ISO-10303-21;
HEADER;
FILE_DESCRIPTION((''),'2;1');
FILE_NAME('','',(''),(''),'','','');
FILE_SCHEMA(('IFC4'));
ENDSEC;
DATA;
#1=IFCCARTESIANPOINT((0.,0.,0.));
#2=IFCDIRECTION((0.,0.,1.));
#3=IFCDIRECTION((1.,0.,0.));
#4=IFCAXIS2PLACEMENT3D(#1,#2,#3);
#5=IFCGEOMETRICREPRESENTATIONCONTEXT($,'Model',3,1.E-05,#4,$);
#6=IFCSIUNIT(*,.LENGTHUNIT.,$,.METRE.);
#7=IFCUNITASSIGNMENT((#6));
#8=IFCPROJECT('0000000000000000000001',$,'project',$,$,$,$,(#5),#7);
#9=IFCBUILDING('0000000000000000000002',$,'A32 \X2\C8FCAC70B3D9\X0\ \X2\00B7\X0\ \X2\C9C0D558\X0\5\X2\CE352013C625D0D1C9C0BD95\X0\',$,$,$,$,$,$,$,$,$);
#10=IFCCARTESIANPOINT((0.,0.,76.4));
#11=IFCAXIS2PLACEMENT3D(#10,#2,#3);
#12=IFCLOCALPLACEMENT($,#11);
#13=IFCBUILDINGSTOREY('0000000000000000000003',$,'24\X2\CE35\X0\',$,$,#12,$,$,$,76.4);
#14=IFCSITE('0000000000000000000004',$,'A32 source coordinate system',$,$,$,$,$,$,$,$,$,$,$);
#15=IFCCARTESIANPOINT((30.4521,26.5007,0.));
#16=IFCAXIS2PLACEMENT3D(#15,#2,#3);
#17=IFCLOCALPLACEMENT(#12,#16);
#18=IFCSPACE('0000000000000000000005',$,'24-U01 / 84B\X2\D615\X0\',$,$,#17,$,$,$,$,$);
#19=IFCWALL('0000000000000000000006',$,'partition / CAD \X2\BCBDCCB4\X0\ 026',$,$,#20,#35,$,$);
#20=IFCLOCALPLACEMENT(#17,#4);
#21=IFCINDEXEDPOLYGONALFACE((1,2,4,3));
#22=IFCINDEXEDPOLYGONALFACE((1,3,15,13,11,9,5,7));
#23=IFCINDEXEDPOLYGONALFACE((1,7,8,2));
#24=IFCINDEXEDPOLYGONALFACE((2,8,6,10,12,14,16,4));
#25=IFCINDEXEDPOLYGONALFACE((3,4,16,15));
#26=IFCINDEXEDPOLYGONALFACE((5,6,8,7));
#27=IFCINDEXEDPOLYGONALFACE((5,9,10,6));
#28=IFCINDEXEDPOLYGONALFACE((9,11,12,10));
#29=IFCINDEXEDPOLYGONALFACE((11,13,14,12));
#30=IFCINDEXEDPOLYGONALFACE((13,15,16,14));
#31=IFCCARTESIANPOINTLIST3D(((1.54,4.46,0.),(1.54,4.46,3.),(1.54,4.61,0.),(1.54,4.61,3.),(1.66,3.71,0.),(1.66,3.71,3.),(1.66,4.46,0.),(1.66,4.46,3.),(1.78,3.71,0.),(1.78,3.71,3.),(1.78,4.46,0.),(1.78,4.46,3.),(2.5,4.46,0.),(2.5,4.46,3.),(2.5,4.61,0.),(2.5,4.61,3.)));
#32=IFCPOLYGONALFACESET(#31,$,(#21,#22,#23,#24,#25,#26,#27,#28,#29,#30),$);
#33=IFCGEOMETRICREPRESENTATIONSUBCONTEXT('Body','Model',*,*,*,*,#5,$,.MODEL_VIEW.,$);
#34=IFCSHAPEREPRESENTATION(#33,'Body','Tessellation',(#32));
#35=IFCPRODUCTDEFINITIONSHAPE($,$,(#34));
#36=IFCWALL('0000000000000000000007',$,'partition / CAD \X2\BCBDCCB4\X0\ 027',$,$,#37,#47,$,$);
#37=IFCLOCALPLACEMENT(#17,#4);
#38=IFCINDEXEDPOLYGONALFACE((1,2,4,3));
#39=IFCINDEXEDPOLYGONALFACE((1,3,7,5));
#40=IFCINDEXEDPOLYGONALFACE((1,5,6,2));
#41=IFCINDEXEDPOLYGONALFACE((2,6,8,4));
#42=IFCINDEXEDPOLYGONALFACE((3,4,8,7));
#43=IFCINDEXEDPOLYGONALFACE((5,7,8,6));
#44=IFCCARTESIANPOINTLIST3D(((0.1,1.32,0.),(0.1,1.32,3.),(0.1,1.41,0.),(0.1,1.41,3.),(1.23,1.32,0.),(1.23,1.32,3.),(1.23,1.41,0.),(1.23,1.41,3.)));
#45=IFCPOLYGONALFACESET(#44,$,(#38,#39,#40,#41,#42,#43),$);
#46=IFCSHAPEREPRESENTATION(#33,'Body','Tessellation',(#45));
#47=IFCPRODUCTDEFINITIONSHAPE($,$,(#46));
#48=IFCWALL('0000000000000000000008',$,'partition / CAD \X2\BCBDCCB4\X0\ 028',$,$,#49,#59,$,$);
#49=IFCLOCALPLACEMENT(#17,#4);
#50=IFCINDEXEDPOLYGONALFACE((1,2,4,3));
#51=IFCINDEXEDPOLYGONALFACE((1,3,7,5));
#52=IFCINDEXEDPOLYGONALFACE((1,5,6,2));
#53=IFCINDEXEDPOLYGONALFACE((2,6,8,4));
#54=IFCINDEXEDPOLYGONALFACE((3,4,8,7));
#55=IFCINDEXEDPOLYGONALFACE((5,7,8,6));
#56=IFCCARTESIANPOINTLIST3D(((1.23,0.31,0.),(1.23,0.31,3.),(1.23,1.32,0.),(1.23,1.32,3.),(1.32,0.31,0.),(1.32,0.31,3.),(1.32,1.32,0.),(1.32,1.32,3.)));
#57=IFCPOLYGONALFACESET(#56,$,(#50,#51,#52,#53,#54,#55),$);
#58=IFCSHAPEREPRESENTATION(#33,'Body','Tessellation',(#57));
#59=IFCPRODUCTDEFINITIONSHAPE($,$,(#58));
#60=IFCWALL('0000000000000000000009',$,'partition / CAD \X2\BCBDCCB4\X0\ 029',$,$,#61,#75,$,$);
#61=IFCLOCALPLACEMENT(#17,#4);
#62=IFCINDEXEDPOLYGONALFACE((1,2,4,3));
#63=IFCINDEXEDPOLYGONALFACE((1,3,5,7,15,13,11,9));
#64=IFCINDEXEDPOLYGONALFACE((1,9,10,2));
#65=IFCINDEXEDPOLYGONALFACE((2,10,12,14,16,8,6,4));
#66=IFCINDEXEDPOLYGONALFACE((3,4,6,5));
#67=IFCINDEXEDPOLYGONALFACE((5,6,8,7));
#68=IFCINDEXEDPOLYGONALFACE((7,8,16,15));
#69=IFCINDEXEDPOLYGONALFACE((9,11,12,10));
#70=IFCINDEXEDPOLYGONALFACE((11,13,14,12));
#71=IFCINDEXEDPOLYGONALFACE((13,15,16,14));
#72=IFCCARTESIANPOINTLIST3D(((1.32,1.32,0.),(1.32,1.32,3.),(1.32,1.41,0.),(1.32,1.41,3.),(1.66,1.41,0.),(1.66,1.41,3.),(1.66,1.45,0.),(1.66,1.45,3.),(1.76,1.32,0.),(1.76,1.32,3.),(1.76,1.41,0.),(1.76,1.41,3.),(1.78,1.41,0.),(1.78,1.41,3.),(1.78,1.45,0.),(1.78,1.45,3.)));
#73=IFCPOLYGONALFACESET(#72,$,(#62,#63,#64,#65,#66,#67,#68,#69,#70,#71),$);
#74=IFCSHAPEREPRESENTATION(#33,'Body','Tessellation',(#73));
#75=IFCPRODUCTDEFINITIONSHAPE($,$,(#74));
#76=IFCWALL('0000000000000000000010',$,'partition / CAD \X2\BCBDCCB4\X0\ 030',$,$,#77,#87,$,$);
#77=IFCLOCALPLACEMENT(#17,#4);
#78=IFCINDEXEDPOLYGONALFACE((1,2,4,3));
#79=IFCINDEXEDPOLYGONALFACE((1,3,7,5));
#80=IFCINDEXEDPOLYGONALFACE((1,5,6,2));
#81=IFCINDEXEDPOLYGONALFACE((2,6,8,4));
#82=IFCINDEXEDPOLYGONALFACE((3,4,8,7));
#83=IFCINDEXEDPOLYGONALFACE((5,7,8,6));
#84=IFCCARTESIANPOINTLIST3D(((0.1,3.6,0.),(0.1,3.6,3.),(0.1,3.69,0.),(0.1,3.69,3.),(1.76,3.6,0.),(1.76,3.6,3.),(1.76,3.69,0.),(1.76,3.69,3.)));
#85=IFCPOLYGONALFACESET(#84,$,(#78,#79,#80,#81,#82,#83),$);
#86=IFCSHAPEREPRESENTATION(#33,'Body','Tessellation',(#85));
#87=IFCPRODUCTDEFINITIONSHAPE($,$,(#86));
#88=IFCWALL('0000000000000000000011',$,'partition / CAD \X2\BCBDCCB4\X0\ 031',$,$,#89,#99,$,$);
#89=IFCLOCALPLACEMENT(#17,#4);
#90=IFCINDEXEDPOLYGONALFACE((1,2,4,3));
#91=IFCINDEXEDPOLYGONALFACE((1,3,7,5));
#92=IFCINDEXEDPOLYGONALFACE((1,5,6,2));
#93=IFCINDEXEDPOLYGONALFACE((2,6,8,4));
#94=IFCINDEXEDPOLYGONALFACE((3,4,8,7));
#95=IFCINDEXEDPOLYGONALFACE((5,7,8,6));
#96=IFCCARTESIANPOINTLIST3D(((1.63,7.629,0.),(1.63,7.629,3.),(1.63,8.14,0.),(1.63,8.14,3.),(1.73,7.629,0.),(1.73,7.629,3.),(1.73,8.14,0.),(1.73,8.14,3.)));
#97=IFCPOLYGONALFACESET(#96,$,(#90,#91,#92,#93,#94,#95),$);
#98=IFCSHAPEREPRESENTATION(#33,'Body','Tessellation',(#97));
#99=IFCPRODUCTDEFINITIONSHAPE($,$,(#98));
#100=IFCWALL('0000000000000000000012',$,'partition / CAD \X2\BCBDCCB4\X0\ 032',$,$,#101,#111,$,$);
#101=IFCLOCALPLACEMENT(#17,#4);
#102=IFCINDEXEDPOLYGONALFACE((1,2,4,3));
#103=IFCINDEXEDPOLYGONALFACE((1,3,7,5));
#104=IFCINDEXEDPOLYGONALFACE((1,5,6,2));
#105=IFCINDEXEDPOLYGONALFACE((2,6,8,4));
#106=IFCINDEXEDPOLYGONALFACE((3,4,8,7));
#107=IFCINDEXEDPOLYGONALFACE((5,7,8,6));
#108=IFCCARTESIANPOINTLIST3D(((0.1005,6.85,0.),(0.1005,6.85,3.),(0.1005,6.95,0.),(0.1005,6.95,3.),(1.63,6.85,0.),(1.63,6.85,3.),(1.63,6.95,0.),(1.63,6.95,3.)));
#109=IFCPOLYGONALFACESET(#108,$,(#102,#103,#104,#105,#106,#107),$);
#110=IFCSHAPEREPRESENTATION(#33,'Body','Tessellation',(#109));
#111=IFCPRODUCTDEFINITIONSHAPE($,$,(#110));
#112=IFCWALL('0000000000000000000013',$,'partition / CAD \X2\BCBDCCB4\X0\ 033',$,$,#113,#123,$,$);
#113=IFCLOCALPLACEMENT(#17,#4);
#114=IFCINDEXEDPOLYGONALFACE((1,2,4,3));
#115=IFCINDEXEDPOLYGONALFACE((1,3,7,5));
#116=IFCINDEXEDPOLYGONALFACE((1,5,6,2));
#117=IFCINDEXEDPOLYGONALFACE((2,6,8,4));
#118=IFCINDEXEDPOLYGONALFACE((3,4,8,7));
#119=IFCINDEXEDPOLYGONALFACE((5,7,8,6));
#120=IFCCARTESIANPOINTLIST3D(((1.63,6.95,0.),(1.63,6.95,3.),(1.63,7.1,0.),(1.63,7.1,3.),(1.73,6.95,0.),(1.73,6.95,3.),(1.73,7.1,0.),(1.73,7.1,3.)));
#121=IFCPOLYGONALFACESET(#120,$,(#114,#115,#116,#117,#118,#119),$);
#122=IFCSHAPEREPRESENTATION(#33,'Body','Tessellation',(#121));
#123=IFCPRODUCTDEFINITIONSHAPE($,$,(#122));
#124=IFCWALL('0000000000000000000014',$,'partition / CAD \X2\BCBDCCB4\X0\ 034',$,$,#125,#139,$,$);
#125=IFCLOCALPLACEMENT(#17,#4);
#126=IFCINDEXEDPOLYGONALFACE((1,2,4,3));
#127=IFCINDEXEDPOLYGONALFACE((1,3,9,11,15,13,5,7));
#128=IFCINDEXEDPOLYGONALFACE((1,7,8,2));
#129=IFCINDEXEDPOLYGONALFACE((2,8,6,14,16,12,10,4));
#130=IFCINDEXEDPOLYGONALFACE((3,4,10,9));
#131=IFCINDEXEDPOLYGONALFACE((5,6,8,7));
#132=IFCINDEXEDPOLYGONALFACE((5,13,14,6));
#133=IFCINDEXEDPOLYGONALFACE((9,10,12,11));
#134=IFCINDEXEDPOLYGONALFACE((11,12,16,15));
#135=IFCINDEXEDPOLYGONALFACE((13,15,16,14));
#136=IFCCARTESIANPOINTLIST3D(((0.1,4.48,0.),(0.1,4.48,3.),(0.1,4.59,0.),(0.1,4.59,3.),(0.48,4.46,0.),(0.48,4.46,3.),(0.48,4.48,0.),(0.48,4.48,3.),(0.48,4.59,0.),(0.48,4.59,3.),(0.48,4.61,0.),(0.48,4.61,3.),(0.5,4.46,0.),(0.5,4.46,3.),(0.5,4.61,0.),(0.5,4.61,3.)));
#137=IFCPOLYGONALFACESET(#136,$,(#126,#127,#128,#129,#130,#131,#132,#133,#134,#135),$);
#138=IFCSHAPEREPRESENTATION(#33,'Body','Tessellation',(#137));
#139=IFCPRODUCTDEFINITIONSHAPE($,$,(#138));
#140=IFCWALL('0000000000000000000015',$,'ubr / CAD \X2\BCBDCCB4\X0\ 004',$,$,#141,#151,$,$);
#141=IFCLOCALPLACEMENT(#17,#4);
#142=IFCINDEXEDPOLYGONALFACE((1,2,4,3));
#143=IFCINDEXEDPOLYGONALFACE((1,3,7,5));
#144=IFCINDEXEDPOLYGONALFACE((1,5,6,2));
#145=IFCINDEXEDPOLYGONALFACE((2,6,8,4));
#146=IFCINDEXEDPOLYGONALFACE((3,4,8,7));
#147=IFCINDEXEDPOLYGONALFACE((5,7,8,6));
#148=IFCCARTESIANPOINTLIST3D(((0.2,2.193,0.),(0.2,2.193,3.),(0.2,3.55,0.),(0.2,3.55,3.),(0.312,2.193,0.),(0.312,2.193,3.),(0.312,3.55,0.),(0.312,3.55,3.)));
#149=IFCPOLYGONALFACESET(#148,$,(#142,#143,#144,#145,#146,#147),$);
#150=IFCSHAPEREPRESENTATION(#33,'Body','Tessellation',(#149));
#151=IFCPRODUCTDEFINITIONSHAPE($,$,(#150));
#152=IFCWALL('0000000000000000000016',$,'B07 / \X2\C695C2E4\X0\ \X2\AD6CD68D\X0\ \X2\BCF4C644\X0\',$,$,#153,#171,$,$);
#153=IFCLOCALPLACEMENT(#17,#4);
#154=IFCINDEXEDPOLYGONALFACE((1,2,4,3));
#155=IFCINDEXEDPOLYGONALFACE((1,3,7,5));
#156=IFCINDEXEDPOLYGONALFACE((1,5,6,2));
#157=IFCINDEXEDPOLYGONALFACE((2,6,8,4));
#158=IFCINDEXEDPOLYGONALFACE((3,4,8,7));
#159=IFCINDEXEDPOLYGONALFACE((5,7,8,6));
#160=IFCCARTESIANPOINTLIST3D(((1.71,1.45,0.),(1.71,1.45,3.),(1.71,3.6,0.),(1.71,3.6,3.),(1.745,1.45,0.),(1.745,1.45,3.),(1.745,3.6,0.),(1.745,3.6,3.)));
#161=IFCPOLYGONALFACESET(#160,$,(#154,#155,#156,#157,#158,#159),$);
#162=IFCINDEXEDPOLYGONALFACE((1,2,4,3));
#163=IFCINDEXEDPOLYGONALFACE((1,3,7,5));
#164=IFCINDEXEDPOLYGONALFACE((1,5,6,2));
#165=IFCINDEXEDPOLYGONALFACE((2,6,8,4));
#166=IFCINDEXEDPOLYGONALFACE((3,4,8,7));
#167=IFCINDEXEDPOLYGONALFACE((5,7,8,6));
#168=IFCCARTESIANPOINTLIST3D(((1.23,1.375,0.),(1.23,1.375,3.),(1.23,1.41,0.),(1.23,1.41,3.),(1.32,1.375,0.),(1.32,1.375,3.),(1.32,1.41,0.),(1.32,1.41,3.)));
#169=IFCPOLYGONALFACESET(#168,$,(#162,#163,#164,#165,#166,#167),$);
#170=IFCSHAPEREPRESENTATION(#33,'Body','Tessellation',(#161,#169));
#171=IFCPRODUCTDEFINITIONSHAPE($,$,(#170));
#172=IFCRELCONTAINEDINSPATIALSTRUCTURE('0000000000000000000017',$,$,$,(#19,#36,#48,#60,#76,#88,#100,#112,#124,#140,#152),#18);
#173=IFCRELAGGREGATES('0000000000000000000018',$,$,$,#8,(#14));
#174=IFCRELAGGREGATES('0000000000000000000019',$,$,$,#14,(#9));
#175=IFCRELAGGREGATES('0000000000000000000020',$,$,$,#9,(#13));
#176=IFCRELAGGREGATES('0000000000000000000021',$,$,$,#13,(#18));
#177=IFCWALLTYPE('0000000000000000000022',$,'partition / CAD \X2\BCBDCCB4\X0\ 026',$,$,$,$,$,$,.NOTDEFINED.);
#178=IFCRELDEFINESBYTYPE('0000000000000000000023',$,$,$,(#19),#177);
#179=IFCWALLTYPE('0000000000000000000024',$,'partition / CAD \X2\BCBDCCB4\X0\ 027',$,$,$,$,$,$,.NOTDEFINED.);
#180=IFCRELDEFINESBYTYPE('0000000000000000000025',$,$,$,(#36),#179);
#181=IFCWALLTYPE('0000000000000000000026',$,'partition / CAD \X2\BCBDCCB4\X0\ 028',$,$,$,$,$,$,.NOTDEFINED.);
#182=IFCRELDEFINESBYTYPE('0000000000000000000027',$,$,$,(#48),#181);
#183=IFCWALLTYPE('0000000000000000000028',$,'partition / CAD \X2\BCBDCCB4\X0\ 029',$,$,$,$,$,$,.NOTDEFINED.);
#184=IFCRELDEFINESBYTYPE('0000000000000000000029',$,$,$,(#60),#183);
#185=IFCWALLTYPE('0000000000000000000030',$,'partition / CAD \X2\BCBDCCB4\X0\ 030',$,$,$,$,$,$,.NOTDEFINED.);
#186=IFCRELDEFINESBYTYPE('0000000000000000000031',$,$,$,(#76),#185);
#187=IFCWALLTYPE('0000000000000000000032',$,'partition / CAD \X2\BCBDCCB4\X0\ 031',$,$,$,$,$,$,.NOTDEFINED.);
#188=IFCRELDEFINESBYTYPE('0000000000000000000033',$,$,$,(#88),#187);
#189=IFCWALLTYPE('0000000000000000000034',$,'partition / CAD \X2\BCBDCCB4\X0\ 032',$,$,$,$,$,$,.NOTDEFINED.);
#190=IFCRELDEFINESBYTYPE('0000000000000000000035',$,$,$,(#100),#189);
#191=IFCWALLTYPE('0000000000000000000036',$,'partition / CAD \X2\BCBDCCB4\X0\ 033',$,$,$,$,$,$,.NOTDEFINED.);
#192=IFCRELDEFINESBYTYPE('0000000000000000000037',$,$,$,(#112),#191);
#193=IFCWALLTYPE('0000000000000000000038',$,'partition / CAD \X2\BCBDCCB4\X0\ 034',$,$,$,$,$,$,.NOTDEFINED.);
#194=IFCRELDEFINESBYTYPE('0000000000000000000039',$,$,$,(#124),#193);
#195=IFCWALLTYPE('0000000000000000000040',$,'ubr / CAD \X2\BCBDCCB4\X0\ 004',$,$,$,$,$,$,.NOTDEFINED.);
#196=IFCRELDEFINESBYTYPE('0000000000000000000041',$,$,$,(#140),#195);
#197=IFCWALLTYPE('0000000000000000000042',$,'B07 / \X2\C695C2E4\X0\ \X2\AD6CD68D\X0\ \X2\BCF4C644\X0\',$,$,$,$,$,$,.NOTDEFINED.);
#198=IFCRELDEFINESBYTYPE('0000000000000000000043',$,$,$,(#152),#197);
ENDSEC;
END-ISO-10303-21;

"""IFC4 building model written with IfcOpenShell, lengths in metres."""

from ifc_helpers import new_model, si_unit, frame, origin, origin_with_axes, place, context, subcontext, project, spatial, polyline, outline, extrude, source, transform, mapped, type_object, type_shapes, element, save


model = new_model("IFC4")

# Units and contexts
model_context = context("Model", 3, precision=1e-05, world=origin_with_axes())
body_context = subcontext(model_context, "Body", "Model", "MODEL_VIEW")
ifc_project = project(units=[si_unit("LENGTHUNIT", "METRE")], contexts=[model_context])

# Site, building, storey, space
site = spatial("IfcSite", under=ifc_project, Name="A32 source coordinate system")
building = spatial("IfcBuilding", under=site, Name="A32 주거동 · 지하5층–옥탑지붕")
storey_placement = place(None, frame((0.0, 0.0, 76.4), z_axis=(0.0, 0.0, 1.0), x_axis=(1.0, 0.0, 0.0)))
storey = spatial("IfcBuildingStorey", under=building, at=storey_placement, Name="24층", Elevation=76.4)
space_placement = place(storey_placement, frame((30.4521, 26.5007, 0.0), z_axis=(0.0, 0.0, 1.0), x_axis=(1.0, 0.0, 0.0)))
space = spatial("IfcSpace", under=storey, at=space_placement, Name="24-U01 / 84B형")

# Walls
wall_type_1 = type_object("IfcWallType", Name="partition / CAD 벽체 026", PredefinedType="NOTDEFINED")
shared_shape_1 = source(origin(), body_context, "Body", "SweptSolid", [
    extrude(outline(polyline([(1.54, 4.46), (1.54, 4.61), (2.5, 4.61), (2.5, 4.46), (1.78, 4.46), (1.78, 3.71), (1.66, 3.71), (1.66, 4.46), (1.54, 4.46)])), origin(), (0.0, 0.0, 1.0), 3.0),
])
type_shapes(wall_type_1, [shared_shape_1])
wall_1_placement = place(space_placement, origin_with_axes())
element("IfcWall", 1, at=wall_1_placement, inside=space, type_object=wall_type_1, Name="partition / CAD 벽체 026", context=body_context, shape_type="MappedRepresentation", body=[
    mapped(shared_shape_1, transform((0.0, 0.0, 0.0), scale=1.0)),
])
wall_type_2 = type_object("IfcWallType", Name="partition / CAD 벽체 027", PredefinedType="NOTDEFINED")
shared_shape_2 = source(origin(), body_context, "Body", "SweptSolid", [
    extrude(outline(polyline([(0.1, 1.32), (0.1, 1.41), (1.23, 1.41), (1.23, 1.32), (0.1, 1.32)])), origin(), (0.0, 0.0, 1.0), 3.0),
])
type_shapes(wall_type_2, [shared_shape_2])
wall_2_placement = place(space_placement, origin_with_axes())
element("IfcWall", 2, at=wall_2_placement, inside=space, type_object=wall_type_2, Name="partition / CAD 벽체 027", context=body_context, shape_type="MappedRepresentation", body=[
    mapped(shared_shape_2, transform((0.0, 0.0, 0.0), scale=1.0)),
])
wall_type_3 = type_object("IfcWallType", Name="partition / CAD 벽체 028", PredefinedType="NOTDEFINED")
shared_shape_3 = source(origin(), body_context, "Body", "SweptSolid", [
    extrude(outline(polyline([(1.32, 0.31), (1.23, 0.31), (1.23, 1.32), (1.32, 1.32), (1.32, 0.31)])), origin(), (0.0, 0.0, 1.0), 3.0),
])
type_shapes(wall_type_3, [shared_shape_3])
wall_3_placement = place(space_placement, origin_with_axes())
element("IfcWall", 3, at=wall_3_placement, inside=space, type_object=wall_type_3, Name="partition / CAD 벽체 028", context=body_context, shape_type="MappedRepresentation", body=[
    mapped(shared_shape_3, transform((0.0, 0.0, 0.0), scale=1.0)),
])
wall_type_4 = type_object("IfcWallType", Name="partition / CAD 벽체 029", PredefinedType="NOTDEFINED")
shared_shape_4 = source(origin(), body_context, "Body", "SweptSolid", [
    extrude(outline(polyline([(1.66, 1.41), (1.66, 1.45), (1.78, 1.45), (1.78, 1.41), (1.76, 1.41), (1.76, 1.32), (1.32, 1.32), (1.32, 1.41), (1.66, 1.41)])), origin(), (0.0, 0.0, 1.0), 3.0),
])
type_shapes(wall_type_4, [shared_shape_4])
wall_4_placement = place(space_placement, origin_with_axes())
element("IfcWall", 4, at=wall_4_placement, inside=space, type_object=wall_type_4, Name="partition / CAD 벽체 029", context=body_context, shape_type="MappedRepresentation", body=[
    mapped(shared_shape_4, transform((0.0, 0.0, 0.0), scale=1.0)),
])
wall_type_5 = type_object("IfcWallType", Name="partition / CAD 벽체 030", PredefinedType="NOTDEFINED")
shared_shape_5 = source(origin(), body_context, "Body", "SweptSolid", [
    extrude(outline(polyline([(1.76, 3.69), (1.76, 3.6), (0.1, 3.6), (0.1, 3.69), (1.76, 3.69)])), origin(), (0.0, 0.0, 1.0), 3.0),
])
type_shapes(wall_type_5, [shared_shape_5])
wall_5_placement = place(space_placement, origin_with_axes())
element("IfcWall", 5, at=wall_5_placement, inside=space, type_object=wall_type_5, Name="partition / CAD 벽체 030", context=body_context, shape_type="MappedRepresentation", body=[
    mapped(shared_shape_5, transform((0.0, 0.0, 0.0), scale=1.0)),
])
wall_type_6 = type_object("IfcWallType", Name="partition / CAD 벽체 031", PredefinedType="NOTDEFINED")
shared_shape_6 = source(origin(), body_context, "Body", "SweptSolid", [
    extrude(outline(polyline([(1.63, 8.14), (1.73, 8.14), (1.73, 7.629), (1.63, 7.629), (1.63, 8.14)])), origin(), (0.0, 0.0, 1.0), 3.0),
])
type_shapes(wall_type_6, [shared_shape_6])
wall_6_placement = place(space_placement, origin_with_axes())
element("IfcWall", 6, at=wall_6_placement, inside=space, type_object=wall_type_6, Name="partition / CAD 벽체 031", context=body_context, shape_type="MappedRepresentation", body=[
    mapped(shared_shape_6, transform((0.0, 0.0, 0.0), scale=1.0)),
])
wall_type_7 = type_object("IfcWallType", Name="partition / CAD 벽체 032", PredefinedType="NOTDEFINED")
shared_shape_7 = source(origin(), body_context, "Body", "SweptSolid", [
    extrude(outline(polyline([(0.1005, 6.95), (1.63, 6.95), (1.63, 6.85), (0.1005, 6.85), (0.1005, 6.95)])), origin(), (0.0, 0.0, 1.0), 3.0),
])
type_shapes(wall_type_7, [shared_shape_7])
wall_7_placement = place(space_placement, origin_with_axes())
element("IfcWall", 7, at=wall_7_placement, inside=space, type_object=wall_type_7, Name="partition / CAD 벽체 032", context=body_context, shape_type="MappedRepresentation", body=[
    mapped(shared_shape_7, transform((0.0, 0.0, 0.0), scale=1.0)),
])
wall_type_8 = type_object("IfcWallType", Name="partition / CAD 벽체 033", PredefinedType="NOTDEFINED")
shared_shape_8 = source(origin(), body_context, "Body", "SweptSolid", [
    extrude(outline(polyline([(1.63, 7.1), (1.73, 7.1), (1.73, 6.95), (1.63, 6.95), (1.63, 7.1)])), origin(), (0.0, 0.0, 1.0), 3.0),
])
type_shapes(wall_type_8, [shared_shape_8])
wall_8_placement = place(space_placement, origin_with_axes())
element("IfcWall", 8, at=wall_8_placement, inside=space, type_object=wall_type_8, Name="partition / CAD 벽체 033", context=body_context, shape_type="MappedRepresentation", body=[
    mapped(shared_shape_8, transform((0.0, 0.0, 0.0), scale=1.0)),
])
wall_type_9 = type_object("IfcWallType", Name="partition / CAD 벽체 034", PredefinedType="NOTDEFINED")
shared_shape_9 = source(origin(), body_context, "Body", "SweptSolid", [
    extrude(outline(polyline([(0.48, 4.61), (0.5, 4.61), (0.5, 4.46), (0.48, 4.46), (0.48, 4.48), (0.1, 4.48), (0.1, 4.59), (0.48, 4.59), (0.48, 4.61)])), origin(), (0.0, 0.0, 1.0), 3.0),
])
type_shapes(wall_type_9, [shared_shape_9])
wall_9_placement = place(space_placement, origin_with_axes())
element("IfcWall", 9, at=wall_9_placement, inside=space, type_object=wall_type_9, Name="partition / CAD 벽체 034", context=body_context, shape_type="MappedRepresentation", body=[
    mapped(shared_shape_9, transform((0.0, 0.0, 0.0), scale=1.0)),
])
wall_type_10 = type_object("IfcWallType", Name="ubr / CAD 벽체 004", PredefinedType="NOTDEFINED")
shared_shape_10 = source(origin(), body_context, "Body", "SweptSolid", [
    extrude(outline(polyline([(0.312, 2.193), (0.2, 2.193), (0.2, 3.55), (0.312, 3.55), (0.312, 2.193)])), origin(), (0.0, 0.0, 1.0), 3.0),
])
type_shapes(wall_type_10, [shared_shape_10])
wall_10_placement = place(space_placement, origin_with_axes())
element("IfcWall", 10, at=wall_10_placement, inside=space, type_object=wall_type_10, Name="ubr / CAD 벽체 004", context=body_context, shape_type="MappedRepresentation", body=[
    mapped(shared_shape_10, transform((0.0, 0.0, 0.0), scale=1.0)),
])
wall_type_11 = type_object("IfcWallType", Name="B07 / 욕실 구획 보완", PredefinedType="NOTDEFINED")
shared_shape_11 = source(origin(), body_context, "Body", "SweptSolid", [
    extrude(outline(polyline([(1.71, 1.45), (1.71, 3.6), (1.745, 3.6), (1.745, 1.45), (1.71, 1.45)])), origin(), (0.0, 0.0, 1.0), 3.0),
    extrude(outline(polyline([(1.32, 1.41), (1.32, 1.375), (1.23, 1.375), (1.23, 1.41), (1.32, 1.41)])), origin(), (0.0, 0.0, 1.0), 3.0),
])
type_shapes(wall_type_11, [shared_shape_11])
wall_11_placement = place(space_placement, origin_with_axes())
element("IfcWall", 11, at=wall_11_placement, inside=space, type_object=wall_type_11, Name="B07 / 욕실 구획 보완", context=body_context, shape_type="MappedRepresentation", body=[
    mapped(shared_shape_11, transform((0.0, 0.0, 0.0), scale=1.0)),
])

save(model, "model.ifc")
